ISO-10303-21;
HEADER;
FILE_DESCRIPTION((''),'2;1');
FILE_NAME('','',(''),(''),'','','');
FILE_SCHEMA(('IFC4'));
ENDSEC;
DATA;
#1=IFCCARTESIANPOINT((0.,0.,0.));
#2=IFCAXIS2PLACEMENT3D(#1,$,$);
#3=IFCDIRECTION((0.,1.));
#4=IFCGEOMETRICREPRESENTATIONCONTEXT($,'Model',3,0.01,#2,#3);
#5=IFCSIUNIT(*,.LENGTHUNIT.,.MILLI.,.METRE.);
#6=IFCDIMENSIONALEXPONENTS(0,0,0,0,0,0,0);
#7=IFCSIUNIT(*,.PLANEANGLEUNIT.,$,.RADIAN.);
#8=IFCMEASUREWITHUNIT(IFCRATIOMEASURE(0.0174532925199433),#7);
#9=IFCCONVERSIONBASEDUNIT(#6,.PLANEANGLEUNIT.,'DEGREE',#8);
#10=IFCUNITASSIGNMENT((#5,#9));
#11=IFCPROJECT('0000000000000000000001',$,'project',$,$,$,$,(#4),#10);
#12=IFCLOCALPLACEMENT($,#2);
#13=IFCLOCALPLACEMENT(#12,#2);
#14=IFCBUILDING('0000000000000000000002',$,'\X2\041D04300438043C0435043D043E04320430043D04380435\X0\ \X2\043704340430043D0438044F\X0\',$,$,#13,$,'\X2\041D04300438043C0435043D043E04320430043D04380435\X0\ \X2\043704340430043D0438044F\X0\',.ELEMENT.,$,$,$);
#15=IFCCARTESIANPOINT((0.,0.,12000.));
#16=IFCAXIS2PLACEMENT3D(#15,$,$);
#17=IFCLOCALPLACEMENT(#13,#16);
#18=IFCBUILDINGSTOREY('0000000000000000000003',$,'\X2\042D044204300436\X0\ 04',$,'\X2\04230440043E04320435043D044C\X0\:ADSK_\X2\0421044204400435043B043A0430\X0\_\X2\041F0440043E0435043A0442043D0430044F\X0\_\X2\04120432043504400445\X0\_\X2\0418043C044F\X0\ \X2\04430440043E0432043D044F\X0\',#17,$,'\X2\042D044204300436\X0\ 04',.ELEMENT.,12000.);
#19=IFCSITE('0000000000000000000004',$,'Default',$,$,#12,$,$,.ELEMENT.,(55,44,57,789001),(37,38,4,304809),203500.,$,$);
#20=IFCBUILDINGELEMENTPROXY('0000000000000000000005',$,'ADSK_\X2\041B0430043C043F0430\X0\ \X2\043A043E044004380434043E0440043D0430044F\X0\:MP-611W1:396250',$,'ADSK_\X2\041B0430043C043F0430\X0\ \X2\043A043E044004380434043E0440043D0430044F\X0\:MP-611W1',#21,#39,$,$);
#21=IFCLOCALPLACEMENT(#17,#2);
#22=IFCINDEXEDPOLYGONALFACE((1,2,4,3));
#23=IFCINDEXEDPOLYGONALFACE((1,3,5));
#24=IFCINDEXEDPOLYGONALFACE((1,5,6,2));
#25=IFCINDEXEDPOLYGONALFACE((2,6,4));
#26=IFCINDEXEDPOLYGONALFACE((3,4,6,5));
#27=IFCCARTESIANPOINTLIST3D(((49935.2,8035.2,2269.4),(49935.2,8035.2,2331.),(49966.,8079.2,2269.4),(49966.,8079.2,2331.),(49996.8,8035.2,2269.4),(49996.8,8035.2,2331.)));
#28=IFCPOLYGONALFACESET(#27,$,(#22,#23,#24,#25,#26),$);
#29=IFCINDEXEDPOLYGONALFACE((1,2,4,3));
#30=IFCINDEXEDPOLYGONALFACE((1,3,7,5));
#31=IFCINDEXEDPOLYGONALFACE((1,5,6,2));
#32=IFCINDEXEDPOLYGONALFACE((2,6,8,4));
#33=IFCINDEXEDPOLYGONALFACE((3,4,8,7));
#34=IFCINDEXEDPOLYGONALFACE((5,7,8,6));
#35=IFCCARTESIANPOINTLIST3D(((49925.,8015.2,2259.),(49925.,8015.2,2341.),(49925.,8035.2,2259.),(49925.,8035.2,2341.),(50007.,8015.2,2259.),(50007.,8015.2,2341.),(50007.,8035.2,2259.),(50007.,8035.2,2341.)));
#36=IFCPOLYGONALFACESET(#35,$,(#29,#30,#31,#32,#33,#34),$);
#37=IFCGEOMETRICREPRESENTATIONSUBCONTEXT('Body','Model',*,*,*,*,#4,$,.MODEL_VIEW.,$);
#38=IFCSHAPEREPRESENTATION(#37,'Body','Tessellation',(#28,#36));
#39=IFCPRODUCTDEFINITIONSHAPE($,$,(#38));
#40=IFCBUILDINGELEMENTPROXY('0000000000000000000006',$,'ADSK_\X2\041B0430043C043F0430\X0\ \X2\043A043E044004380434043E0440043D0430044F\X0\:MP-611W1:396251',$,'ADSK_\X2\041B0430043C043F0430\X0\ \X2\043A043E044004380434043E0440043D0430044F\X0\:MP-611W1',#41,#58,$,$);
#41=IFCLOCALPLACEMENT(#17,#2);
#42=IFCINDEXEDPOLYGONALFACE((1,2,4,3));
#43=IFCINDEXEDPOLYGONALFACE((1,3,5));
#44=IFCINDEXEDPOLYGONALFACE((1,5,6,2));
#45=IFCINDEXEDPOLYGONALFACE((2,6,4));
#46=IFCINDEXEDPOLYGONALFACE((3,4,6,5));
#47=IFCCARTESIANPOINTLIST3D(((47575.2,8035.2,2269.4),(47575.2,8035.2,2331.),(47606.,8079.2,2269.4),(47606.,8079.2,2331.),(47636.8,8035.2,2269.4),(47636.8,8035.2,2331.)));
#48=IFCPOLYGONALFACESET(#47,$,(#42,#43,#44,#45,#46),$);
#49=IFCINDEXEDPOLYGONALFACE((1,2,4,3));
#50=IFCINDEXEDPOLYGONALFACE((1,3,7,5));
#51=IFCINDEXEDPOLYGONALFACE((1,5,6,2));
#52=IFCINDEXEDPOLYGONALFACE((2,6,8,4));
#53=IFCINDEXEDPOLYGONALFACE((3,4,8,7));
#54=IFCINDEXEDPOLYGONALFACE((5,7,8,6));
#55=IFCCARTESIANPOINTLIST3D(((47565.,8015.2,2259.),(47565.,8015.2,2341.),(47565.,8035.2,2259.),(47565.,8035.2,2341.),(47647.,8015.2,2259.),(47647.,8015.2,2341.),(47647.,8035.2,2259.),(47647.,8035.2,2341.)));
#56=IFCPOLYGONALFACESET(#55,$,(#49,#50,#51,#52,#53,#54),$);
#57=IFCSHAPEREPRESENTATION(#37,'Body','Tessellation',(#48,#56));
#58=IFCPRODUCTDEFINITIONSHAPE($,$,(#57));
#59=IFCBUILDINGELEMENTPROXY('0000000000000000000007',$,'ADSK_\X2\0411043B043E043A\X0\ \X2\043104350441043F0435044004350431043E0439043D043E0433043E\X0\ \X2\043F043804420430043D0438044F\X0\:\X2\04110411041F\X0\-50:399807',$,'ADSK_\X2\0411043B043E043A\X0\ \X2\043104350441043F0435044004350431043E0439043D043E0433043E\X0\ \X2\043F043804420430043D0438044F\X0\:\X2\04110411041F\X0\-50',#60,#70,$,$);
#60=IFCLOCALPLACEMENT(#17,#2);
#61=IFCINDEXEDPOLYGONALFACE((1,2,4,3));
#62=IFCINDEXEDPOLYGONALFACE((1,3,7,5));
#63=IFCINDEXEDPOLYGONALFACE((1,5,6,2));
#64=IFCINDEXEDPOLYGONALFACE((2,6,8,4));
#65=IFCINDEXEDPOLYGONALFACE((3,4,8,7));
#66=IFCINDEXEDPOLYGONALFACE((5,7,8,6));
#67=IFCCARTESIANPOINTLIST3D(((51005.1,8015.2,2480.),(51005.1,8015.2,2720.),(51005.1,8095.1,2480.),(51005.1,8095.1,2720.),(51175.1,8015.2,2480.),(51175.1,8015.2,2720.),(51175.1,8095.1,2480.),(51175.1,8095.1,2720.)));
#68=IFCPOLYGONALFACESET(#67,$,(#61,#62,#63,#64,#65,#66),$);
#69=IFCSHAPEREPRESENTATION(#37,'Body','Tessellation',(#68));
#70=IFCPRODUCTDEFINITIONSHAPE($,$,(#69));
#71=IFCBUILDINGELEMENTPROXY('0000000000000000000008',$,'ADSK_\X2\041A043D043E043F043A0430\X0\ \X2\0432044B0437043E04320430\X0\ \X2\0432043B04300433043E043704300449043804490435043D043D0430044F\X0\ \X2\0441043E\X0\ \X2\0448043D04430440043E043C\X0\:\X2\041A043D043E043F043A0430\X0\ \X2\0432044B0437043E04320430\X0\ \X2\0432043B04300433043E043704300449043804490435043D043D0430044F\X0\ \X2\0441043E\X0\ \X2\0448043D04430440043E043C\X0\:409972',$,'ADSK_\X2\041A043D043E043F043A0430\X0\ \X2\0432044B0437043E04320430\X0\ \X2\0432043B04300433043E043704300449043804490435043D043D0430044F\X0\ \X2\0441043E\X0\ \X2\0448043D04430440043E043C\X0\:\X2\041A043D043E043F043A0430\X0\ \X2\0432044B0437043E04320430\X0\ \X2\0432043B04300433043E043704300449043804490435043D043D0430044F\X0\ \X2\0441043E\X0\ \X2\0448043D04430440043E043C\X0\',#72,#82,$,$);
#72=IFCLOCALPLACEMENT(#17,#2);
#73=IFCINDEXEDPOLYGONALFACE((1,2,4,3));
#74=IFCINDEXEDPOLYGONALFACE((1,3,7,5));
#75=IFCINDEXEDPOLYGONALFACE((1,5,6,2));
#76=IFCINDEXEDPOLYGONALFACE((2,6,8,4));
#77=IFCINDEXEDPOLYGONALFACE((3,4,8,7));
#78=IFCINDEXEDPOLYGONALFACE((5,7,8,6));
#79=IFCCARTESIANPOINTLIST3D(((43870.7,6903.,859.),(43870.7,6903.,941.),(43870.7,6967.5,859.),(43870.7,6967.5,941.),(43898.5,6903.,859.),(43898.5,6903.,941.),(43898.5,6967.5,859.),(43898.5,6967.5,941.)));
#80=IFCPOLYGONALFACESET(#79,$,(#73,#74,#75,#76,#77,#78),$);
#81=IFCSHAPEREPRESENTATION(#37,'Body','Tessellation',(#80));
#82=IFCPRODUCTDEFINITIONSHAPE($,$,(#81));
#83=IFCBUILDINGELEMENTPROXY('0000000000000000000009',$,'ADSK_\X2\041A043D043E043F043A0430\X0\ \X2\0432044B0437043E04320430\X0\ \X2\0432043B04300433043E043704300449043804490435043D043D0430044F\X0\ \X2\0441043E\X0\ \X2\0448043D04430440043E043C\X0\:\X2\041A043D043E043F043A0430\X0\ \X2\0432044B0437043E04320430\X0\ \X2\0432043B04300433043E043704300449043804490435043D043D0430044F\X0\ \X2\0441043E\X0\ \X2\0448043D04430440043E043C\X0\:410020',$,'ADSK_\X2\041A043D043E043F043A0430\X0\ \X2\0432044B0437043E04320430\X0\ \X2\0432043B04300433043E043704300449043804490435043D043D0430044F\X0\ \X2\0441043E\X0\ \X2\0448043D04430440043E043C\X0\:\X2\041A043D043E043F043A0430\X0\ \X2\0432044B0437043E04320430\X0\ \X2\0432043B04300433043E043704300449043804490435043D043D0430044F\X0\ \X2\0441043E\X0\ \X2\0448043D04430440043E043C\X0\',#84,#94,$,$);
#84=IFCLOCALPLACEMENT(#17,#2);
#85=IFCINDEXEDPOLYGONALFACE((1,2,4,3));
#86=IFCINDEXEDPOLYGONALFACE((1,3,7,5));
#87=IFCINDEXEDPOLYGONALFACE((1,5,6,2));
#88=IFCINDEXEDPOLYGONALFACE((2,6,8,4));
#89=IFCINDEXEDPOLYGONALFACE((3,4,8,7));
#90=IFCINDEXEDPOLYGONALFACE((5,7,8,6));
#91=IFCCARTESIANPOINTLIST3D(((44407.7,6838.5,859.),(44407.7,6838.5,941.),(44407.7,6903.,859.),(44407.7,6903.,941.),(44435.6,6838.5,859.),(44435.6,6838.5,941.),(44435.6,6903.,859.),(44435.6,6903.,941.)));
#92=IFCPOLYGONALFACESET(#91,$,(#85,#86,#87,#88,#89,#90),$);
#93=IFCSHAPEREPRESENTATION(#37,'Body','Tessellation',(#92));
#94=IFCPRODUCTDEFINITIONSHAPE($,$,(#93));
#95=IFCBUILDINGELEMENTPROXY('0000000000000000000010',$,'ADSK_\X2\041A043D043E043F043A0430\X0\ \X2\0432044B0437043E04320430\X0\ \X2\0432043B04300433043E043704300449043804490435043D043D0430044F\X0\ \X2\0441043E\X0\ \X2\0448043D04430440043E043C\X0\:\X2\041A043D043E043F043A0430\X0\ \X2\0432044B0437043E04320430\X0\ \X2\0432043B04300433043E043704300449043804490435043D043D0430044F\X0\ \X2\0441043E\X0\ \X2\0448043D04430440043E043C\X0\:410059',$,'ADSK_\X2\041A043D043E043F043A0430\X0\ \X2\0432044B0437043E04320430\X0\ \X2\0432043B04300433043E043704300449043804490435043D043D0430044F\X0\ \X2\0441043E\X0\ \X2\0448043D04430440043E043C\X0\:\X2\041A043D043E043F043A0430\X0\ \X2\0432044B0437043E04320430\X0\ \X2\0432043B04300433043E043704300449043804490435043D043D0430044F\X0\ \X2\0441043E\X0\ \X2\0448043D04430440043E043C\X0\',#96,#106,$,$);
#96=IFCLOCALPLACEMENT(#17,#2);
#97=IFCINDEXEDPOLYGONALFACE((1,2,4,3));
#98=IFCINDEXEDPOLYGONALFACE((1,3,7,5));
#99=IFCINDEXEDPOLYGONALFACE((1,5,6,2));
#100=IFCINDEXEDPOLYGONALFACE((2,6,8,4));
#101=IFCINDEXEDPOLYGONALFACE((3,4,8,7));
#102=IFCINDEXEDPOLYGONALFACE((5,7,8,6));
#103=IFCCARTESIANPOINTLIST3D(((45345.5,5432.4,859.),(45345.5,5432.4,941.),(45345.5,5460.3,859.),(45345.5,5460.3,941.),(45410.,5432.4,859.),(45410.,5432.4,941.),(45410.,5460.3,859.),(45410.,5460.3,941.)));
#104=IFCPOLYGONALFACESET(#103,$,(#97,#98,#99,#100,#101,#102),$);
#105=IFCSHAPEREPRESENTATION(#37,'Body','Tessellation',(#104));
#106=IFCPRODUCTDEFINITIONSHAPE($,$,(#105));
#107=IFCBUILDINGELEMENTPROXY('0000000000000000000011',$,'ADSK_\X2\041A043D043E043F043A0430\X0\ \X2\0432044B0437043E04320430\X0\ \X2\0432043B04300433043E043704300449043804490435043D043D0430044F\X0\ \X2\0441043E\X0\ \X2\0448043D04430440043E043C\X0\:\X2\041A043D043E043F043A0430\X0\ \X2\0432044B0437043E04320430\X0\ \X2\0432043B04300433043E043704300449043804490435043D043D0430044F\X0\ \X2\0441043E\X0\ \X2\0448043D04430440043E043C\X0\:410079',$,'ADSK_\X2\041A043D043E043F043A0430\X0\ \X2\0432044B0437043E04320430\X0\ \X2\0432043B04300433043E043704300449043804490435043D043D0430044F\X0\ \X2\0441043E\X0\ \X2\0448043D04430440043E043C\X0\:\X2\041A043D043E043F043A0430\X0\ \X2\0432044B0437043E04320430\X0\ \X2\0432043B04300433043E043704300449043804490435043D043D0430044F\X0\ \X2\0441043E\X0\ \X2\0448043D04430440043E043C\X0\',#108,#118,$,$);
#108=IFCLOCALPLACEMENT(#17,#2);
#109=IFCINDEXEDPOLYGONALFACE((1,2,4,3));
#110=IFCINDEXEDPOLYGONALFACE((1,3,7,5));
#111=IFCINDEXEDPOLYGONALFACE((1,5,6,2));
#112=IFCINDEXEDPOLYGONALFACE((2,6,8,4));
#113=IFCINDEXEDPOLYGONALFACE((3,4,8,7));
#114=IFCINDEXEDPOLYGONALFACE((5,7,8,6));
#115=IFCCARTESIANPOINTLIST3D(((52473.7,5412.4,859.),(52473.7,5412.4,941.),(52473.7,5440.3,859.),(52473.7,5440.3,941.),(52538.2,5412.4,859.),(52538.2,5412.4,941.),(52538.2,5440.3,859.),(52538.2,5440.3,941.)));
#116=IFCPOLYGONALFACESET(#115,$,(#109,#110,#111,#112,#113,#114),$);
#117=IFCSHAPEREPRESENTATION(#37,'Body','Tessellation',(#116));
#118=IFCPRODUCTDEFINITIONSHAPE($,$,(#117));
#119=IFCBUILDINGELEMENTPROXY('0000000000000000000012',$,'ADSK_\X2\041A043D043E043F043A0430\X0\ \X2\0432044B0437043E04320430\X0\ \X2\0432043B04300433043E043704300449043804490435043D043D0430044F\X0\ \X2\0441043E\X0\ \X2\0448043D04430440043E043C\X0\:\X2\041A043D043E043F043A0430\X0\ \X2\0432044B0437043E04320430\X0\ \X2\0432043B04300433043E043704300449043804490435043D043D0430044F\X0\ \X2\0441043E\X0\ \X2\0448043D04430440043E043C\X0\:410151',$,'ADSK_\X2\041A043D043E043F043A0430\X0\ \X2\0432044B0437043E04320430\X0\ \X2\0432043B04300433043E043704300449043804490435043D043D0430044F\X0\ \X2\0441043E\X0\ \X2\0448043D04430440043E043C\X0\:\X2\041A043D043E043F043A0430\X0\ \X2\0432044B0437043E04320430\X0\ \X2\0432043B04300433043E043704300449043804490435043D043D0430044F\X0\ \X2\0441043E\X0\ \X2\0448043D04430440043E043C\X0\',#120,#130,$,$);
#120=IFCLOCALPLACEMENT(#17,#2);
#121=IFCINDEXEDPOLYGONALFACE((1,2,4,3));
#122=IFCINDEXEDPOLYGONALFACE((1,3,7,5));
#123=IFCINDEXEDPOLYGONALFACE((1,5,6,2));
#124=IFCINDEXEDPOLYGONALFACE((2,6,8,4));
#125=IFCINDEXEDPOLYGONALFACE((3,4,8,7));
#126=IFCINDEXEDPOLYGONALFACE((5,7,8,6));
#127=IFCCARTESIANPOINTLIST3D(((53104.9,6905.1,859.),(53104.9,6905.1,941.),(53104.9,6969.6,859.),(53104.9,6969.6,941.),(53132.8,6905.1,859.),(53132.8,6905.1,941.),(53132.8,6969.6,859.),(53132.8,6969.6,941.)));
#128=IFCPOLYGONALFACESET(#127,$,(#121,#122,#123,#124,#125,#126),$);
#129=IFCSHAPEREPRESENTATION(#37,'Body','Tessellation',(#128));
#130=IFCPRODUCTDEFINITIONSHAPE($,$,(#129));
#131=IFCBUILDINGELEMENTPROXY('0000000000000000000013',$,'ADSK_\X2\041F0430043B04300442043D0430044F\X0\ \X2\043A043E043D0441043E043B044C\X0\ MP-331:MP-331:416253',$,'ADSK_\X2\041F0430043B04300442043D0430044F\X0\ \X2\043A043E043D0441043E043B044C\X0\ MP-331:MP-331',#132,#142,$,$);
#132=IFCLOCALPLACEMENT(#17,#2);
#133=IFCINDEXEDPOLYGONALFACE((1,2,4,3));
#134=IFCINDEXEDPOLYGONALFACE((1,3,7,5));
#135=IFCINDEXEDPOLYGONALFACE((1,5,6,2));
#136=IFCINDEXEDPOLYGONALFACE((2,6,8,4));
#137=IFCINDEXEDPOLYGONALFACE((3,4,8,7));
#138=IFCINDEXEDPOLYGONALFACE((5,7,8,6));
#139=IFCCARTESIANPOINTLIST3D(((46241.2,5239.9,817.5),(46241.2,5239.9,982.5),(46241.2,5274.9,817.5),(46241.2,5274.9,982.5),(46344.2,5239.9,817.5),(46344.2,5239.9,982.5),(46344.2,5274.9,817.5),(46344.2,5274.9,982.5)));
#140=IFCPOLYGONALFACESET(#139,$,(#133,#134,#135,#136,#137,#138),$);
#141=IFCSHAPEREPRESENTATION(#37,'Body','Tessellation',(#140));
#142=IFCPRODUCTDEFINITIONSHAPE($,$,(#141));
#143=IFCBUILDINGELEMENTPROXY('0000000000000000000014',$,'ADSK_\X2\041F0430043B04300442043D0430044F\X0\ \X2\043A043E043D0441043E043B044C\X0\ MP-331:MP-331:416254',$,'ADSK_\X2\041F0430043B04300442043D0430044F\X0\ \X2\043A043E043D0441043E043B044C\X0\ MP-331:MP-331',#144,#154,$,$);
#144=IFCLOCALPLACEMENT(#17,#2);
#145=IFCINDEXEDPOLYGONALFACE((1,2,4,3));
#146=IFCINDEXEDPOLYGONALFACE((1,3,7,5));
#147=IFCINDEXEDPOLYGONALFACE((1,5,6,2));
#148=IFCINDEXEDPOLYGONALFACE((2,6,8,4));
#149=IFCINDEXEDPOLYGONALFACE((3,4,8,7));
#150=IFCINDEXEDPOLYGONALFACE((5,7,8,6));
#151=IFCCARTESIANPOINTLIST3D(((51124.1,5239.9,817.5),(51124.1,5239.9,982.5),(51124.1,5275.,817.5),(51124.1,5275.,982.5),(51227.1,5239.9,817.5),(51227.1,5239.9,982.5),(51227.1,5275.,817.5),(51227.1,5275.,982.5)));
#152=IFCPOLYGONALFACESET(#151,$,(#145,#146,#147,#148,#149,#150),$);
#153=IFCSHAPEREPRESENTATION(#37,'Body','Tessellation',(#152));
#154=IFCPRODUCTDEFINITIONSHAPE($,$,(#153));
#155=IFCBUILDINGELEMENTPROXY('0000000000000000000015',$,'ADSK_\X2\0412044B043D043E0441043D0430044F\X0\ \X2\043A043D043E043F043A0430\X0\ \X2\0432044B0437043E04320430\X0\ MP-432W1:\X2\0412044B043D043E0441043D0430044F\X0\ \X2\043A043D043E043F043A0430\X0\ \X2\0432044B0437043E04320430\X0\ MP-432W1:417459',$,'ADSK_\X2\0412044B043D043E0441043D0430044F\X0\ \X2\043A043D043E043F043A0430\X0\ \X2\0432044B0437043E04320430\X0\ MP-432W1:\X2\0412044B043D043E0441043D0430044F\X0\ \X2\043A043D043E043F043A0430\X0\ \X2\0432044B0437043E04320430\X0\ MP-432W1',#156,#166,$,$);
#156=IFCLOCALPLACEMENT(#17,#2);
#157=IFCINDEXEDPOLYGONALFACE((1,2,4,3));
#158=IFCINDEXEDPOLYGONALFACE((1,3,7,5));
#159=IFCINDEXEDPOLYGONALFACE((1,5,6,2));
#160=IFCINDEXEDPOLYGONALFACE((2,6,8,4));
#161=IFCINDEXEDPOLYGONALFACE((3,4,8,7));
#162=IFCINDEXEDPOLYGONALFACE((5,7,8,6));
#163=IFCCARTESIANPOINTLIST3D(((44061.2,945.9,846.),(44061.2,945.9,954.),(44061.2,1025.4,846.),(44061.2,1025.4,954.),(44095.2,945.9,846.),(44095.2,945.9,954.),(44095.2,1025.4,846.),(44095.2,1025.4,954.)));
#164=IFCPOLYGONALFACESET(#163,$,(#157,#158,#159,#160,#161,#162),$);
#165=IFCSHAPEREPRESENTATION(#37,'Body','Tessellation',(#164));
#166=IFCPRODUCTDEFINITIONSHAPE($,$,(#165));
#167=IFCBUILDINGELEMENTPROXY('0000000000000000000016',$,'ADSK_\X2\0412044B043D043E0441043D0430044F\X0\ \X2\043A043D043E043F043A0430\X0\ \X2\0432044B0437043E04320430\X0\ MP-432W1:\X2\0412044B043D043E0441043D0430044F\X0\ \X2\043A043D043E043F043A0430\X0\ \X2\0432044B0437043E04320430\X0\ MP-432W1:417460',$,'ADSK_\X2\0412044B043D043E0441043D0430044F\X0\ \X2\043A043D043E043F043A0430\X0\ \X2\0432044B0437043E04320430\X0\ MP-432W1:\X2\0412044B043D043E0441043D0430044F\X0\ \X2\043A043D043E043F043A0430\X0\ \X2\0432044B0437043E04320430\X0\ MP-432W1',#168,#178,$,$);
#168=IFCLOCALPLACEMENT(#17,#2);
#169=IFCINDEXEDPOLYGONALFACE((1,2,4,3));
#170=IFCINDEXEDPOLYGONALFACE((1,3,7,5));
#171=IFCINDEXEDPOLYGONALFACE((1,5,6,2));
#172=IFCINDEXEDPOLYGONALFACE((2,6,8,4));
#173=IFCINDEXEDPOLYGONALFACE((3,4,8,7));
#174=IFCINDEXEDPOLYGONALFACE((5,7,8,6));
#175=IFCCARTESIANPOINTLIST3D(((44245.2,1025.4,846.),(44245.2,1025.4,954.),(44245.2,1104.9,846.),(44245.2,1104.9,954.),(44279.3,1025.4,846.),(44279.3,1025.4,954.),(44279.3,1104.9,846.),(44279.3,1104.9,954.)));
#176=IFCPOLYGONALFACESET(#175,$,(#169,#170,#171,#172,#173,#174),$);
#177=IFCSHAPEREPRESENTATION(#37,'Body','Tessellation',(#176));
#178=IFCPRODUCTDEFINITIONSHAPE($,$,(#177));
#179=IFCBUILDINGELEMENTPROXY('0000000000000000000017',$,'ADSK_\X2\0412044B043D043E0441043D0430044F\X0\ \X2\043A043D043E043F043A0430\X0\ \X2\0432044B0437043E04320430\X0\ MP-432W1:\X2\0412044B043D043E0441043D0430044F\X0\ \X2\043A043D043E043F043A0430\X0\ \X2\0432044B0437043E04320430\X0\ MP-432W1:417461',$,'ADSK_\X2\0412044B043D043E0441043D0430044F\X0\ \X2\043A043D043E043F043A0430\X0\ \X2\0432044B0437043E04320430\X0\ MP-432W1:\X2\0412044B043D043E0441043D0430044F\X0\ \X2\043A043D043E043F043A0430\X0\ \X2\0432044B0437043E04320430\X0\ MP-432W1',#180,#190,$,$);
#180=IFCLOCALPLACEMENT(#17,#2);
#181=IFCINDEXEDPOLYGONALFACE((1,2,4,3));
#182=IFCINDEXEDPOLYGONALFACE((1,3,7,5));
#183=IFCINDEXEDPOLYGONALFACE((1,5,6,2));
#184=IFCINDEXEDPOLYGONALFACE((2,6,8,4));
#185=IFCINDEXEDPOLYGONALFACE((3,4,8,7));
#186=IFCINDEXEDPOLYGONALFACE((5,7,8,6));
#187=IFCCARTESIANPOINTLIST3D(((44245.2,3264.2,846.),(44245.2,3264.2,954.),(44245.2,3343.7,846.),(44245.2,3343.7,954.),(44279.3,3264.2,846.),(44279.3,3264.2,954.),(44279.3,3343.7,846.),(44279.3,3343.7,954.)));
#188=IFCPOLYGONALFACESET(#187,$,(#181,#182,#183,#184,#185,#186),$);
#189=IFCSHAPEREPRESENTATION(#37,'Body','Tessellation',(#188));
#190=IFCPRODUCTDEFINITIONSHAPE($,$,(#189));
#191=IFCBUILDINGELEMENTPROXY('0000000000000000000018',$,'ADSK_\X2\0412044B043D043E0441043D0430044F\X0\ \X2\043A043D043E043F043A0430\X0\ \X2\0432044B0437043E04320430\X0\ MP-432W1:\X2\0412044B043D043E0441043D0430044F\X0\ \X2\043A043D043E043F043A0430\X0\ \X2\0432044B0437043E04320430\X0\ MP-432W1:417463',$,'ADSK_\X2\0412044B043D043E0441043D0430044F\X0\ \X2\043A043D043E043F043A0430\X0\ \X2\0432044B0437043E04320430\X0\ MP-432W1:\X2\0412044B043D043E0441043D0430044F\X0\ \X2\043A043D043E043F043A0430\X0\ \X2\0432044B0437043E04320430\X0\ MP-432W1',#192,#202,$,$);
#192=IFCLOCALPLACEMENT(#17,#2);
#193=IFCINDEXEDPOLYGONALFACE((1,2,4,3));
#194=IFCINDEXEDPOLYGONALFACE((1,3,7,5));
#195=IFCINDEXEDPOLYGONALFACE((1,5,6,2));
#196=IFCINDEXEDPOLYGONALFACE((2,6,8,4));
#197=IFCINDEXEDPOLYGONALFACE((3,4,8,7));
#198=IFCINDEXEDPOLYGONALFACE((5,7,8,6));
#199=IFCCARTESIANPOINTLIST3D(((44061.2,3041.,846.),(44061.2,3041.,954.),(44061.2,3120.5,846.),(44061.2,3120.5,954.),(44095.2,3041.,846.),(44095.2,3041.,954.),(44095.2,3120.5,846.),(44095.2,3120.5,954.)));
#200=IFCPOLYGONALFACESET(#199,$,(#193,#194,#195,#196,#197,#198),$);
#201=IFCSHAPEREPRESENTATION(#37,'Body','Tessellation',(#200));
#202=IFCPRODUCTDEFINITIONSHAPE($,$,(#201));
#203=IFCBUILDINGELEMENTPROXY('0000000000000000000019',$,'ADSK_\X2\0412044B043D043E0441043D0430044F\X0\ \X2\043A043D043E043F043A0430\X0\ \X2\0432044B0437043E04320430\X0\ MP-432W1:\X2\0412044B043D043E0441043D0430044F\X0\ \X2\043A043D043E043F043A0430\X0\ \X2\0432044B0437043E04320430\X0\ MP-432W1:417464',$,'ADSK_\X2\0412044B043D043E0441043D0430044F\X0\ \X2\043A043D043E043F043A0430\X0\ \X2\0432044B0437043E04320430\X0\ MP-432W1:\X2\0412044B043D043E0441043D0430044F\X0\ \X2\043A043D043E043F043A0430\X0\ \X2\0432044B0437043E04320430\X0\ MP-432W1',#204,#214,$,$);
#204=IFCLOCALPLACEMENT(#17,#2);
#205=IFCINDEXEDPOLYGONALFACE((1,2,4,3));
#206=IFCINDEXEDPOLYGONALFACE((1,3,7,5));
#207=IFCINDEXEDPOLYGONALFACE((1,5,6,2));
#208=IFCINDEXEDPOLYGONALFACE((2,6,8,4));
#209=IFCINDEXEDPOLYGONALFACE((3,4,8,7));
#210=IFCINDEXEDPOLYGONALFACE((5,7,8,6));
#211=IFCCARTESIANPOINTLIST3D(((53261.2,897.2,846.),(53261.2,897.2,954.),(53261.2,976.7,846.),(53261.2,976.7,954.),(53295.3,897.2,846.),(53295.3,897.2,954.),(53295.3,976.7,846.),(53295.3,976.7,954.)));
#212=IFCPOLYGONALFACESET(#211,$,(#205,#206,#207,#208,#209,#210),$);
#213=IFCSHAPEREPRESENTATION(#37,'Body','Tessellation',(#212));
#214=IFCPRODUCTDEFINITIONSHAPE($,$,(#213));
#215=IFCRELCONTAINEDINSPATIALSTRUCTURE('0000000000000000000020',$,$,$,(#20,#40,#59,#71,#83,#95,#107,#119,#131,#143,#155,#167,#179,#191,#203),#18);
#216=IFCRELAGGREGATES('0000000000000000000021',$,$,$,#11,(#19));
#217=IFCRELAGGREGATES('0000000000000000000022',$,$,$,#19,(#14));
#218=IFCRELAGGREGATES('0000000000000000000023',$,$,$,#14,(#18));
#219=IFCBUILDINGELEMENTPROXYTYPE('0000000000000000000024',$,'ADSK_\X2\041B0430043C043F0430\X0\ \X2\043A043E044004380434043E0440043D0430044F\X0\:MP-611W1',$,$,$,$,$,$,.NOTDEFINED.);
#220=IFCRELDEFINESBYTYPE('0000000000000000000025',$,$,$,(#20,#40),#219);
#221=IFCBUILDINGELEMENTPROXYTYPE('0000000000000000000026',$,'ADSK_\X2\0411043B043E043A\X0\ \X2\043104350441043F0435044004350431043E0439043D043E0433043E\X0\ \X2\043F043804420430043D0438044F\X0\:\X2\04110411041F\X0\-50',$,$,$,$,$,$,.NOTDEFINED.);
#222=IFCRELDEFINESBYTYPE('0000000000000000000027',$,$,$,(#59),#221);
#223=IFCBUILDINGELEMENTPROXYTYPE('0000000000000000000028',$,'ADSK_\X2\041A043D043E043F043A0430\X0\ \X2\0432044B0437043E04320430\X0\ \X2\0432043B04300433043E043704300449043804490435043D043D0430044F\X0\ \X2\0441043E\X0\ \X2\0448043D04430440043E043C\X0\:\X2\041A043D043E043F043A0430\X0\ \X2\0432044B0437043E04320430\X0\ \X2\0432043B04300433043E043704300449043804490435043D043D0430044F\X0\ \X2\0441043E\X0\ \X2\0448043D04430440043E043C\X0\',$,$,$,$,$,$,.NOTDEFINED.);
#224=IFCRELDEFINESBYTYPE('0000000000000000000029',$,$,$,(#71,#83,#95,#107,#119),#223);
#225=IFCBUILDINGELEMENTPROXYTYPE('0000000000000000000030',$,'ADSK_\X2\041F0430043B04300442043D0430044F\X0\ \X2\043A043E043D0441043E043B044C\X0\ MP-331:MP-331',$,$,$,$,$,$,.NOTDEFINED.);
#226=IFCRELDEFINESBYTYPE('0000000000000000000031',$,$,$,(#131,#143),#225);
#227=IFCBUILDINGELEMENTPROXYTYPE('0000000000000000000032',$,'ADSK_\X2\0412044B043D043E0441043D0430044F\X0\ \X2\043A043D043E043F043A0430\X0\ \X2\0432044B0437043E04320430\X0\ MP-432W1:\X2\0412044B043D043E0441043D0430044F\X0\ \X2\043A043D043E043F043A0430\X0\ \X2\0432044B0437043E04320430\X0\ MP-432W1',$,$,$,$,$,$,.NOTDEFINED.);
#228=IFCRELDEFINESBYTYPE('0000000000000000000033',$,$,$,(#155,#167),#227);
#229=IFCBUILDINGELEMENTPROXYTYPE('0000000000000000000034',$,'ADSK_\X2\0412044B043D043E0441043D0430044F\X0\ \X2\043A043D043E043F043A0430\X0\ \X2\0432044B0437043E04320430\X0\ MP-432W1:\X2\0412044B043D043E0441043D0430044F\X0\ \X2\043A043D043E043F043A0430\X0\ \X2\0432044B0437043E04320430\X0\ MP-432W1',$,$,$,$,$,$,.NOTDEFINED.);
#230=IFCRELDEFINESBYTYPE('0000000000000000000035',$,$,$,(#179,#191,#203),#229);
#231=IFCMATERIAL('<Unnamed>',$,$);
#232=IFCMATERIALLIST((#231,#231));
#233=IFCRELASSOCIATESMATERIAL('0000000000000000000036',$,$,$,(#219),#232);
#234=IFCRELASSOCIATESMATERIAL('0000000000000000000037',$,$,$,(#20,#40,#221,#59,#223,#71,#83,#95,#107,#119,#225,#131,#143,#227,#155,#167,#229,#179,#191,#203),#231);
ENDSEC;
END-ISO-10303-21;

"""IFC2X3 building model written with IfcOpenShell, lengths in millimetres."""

from ifc_helpers import new_model, entity, si_unit, converted_unit, direction, frame, origin, origin_2d_with_axis, place, context, subcontext, project, spatial, polyline, rectangle, outline, extrude, source, transform, mapped, material, material_list, type_object, type_shapes, element, save


model = new_model("IFC2X3")

# Units and contexts
model_context = context("Model", 3, precision=0.01, world=origin(), true_north=direction((0.0, 1.0)))
body_context = subcontext(model_context, "Body", "Model", "MODEL_VIEW")
ifc_project = project(units=[si_unit("LENGTHUNIT", "METRE", prefix="MILLI"), converted_unit("PLANEANGLEUNIT", "DEGREE", entity("IfcRatioMeasure", 0.0174532925199433), si_unit("PLANEANGLEUNIT", "RADIAN"), dimensions=[0, 0, 0, 0, 0, 0, 0])], contexts=[model_context])

# Site, building, storey
site_placement = place(None, origin())
site = spatial("IfcSite", under=ifc_project, at=site_placement, Name="Default", CompositionType="ELEMENT", RefLatitude=(55, 44, 57, 789001), RefLongitude=(37, 38, 4, 304809), RefElevation=203500.0)
building_placement = place(site_placement, origin())
building = spatial("IfcBuilding", under=site, at=building_placement, Name="Наименование здания", LongName="Наименование здания", CompositionType="ELEMENT")
storey_placement = place(building_placement, frame((0.0, 0.0, 12000.0)))
storey = spatial("IfcBuildingStorey", under=building, at=storey_placement, Name="Этаж 04", ObjectType="Уровень:ADSK_Стрелка_Проектная_Вверх_Имя уровня", LongName="Этаж 04", CompositionType="ELEMENT", Elevation=12000.0)

# Building element proxies
ifc_material = material(Name="<Unnamed>")
ifc_material_list = material_list([ifc_material, ifc_material])
building_element_proxy_type_1 = type_object("IfcBuildingElementProxyType", Name="ADSK_Лампа коридорная:MP-611W1", PredefinedType="NOTDEFINED", material=ifc_material_list)
shared_shape_1 = source(origin(), body_context, "Body", "SweptSolid", [
    extrude(outline(polyline([(-30.8, -14.7), (30.8, -14.7), (0.0, 29.3), (-30.8, -14.7)])), frame((0.0, -2.7, -30.6), z_axis=(0.0, 0.0, 1.0), x_axis=(-1.0, 0.0, 0.0)), (0.0, 0.0, 1.0), 61.6),
    extrude(rectangle(XDim=82.0, YDim=20.0, at=origin_2d_with_axis()), frame((0.0, 22.0, -41.0), z_axis=(0.0, 0.0, 1.0), x_axis=(-1.0, 0.0, 0.0)), (0.0, 0.0, 1.0), 82.0),
])
type_shapes(building_element_proxy_type_1, [shared_shape_1])
for number, where, z_axis, x_axis, name in (
    (1, (49966.0, 8047.1, 2300.0), (0.0, 0.0, 1.0), (-1.0, 0.0, 0.0), "ADSK_Лампа коридорная:MP-611W1:396250"),
    (2, (47606.0, 8047.1, 2300.0), (0.0, 0.0, 1.0), (-1.0, 0.0, 0.0), "ADSK_Лампа коридорная:MP-611W1:396251"),
):
    element("IfcBuildingElementProxy", number, at=place(storey_placement, frame(where, z_axis=z_axis, x_axis=x_axis)), inside=storey, type_object=building_element_proxy_type_1, material=ifc_material, Name=name, ObjectType="ADSK_Лампа коридорная:MP-611W1", context=body_context, shape_type="MappedRepresentation", body=[
        mapped(shared_shape_1, transform((0.0, 0.0, 0.0), scale=1.0)),
    ])
building_element_proxy_type_2 = type_object("IfcBuildingElementProxyType", Name="ADSK_Блок бесперебойного питания:ББП-50", PredefinedType="NOTDEFINED", material=ifc_material)
shared_shape_2 = source(origin(), body_context, "Body", "SweptSolid", [
    extrude(rectangle(XDim=170.0, YDim=80.0, at=origin_2d_with_axis()), frame((0.0, -8.0, -120.0), z_axis=(0.0, 0.0, 1.0), x_axis=(-1.0, 0.0, 0.0)), (0.0, 0.0, 1.0), 240.0),
])
type_shapes(building_element_proxy_type_2, [shared_shape_2])
proxy_1_placement = place(storey_placement, frame((51090.1, 8047.1, 2600.0), z_axis=(0.0, 0.0, 1.0), x_axis=(-1.0, 0.0, 0.0)))
element("IfcBuildingElementProxy", 3, at=proxy_1_placement, inside=storey, type_object=building_element_proxy_type_2, material=ifc_material, Name="ADSK_Блок бесперебойного питания:ББП-50:399807", ObjectType="ADSK_Блок бесперебойного питания:ББП-50", context=body_context, shape_type="MappedRepresentation", body=[
    mapped(shared_shape_2, transform((0.0, 0.0, 0.0), scale=1.0)),
])
building_element_proxy_type_3 = type_object("IfcBuildingElementProxyType", Name="ADSK_Кнопка вызова влагозащищенная со шнуром:Кнопка вызова влагозащищенная со шнуром", PredefinedType="NOTDEFINED", material=ifc_material)
shared_shape_3 = source(origin(), body_context, "Body", "SweptSolid", [
    extrude(rectangle(XDim=64.5, YDim=27.8, at=origin_2d_with_axis()), frame((32.2, 13.9, 0.0), z_axis=(0.0, 0.0, 1.0), x_axis=(-1.0, 0.0, 0.0)), (0.0, 0.0, 1.0), 82.0),
])
type_shapes(building_element_proxy_type_3, [shared_shape_3])
for number, where, z_axis, x_axis, name in (
    (4, (43870.7, 6967.5, 859.0), (0.0, 0.0, 1.0), (0.0, -1.0, 0.0), "ADSK_Кнопка вызова влагозащищенная со шнуром:Кнопка вызова влагозащищенная со шнуром:409972"),
    (5, (44435.6, 6838.5, 859.0), (0.0, 0.0, 1.0), (0.0, 1.0, 0.0), "ADSK_Кнопка вызова влагозащищенная со шнуром:Кнопка вызова влагозащищенная со шнуром:410020"),
    (6, (45410.0, 5460.3, 859.0), (0.0, 0.0, 1.0), (-1.0, 0.0, 0.0), "ADSK_Кнопка вызова влагозащищенная со шнуром:Кнопка вызова влагозащищенная со шнуром:410059"),
    (7, (52538.2, 5440.3, 859.0), (0.0, 0.0, 1.0), (-1.0, 0.0, 0.0), "ADSK_Кнопка вызова влагозащищенная со шнуром:Кнопка вызова влагозащищенная со шнуром:410079"),
    (8, (53104.9, 6969.6, 859.0), (0.0, 0.0, 1.0), (0.0, -1.0, 0.0), "ADSK_Кнопка вызова влагозащищенная со шнуром:Кнопка вызова влагозащищенная со шнуром:410151"),
):
    element("IfcBuildingElementProxy", number, at=place(storey_placement, frame(where, z_axis=z_axis, x_axis=x_axis)), inside=storey, type_object=building_element_proxy_type_3, material=ifc_material, Name=name, ObjectType="ADSK_Кнопка вызова влагозащищенная со шнуром:Кнопка вызова влагозащищенная со шнуром", context=body_context, shape_type="MappedRepresentation", body=[
        mapped(shared_shape_3, transform((0.0, 0.0, 0.0), scale=1.0)),
    ])
building_element_proxy_type_4 = type_object("IfcBuildingElementProxyType", Name="ADSK_Палатная консоль MP-331:MP-331", PredefinedType="NOTDEFINED", material=ifc_material)
shared_shape_4 = source(origin(), body_context, "Body", "SweptSolid", [
    extrude(rectangle(XDim=103.0, YDim=35.0, at=origin_2d_with_axis()), frame((0.0, 14.5, -82.5), z_axis=(0.0, 0.0, 1.0), x_axis=(-1.0, 0.0, 0.0)), (0.0, 0.0, 1.0), 165.0),
])
type_shapes(building_element_proxy_type_4, [shared_shape_4])
for number, where, name in (
    (9, (46292.7, 5242.9, 900.0), "ADSK_Палатная консоль MP-331:MP-331:416253"),
    (10, (51175.6, 5242.9, 900.0), "ADSK_Палатная консоль MP-331:MP-331:416254"),
):
    element("IfcBuildingElementProxy", number, at=place(storey_placement, frame(where)), inside=storey, type_object=building_element_proxy_type_4, material=ifc_material, Name=name, ObjectType="ADSK_Палатная консоль MP-331:MP-331", context=body_context, shape_type="MappedRepresentation", body=[
        mapped(shared_shape_4, transform((0.0, 0.0, 0.0), scale=1.0)),
    ])
building_element_proxy_type_5 = type_object("IfcBuildingElementProxyType", Name="ADSK_Выносная кнопка вызова MP-432W1:Выносная кнопка вызова MP-432W1", PredefinedType="NOTDEFINED", material=ifc_material)
shared_shape_5 = source(origin(), body_context, "Body", "SweptSolid", [
    extrude(rectangle(XDim=79.5, YDim=34.1, at=origin_2d_with_axis()), frame((0.0, 15.0, -54.0), z_axis=(0.0, 0.0, 1.0), x_axis=(-1.0, 0.0, 0.0)), (0.0, 0.0, 1.0), 108.0),
])
type_shapes(building_element_proxy_type_5, [shared_shape_5])
for number, where, z_axis, x_axis, name in (
    (11, (44063.2, 985.6, 900.0), (0.0, 0.0, 1.0), (0.0, -1.0, 0.0), "ADSK_Выносная кнопка вызова MP-432W1:Выносная кнопка вызова MP-432W1:417459"),
    (12, (44277.2, 1065.1, 900.0), (0.0, 0.0, 1.0), (0.0, 1.0, 0.0), "ADSK_Выносная кнопка вызова MP-432W1:Выносная кнопка вызова MP-432W1:417460"),
):
    element("IfcBuildingElementProxy", number, at=place(storey_placement, frame(where, z_axis=z_axis, x_axis=x_axis)), inside=storey, type_object=building_element_proxy_type_5, material=ifc_material, Name=name, ObjectType="ADSK_Выносная кнопка вызова MP-432W1:Выносная кнопка вызова MP-432W1", context=body_context, shape_type="MappedRepresentation", body=[
        mapped(shared_shape_5, transform((0.0, 0.0, 0.0), scale=1.0)),
    ])
building_element_proxy_type_6 = type_object("IfcBuildingElementProxyType", Name="ADSK_Выносная кнопка вызова MP-432W1:Выносная кнопка вызова MP-432W1", PredefinedType="NOTDEFINED", material=ifc_material)
type_shapes(building_element_proxy_type_6, [shared_shape_5])
for number, where, z_axis, x_axis, name in (
    (13, (44277.2, 3304.0, 900.0), (0.0, 0.0, 1.0), (0.0, 1.0, 0.0), "ADSK_Выносная кнопка вызова MP-432W1:Выносная кнопка вызова MP-432W1:417461"),
    (14, (44063.2, 3080.8, 900.0), (0.0, 0.0, 1.0), (0.0, -1.0, 0.0), "ADSK_Выносная кнопка вызова MP-432W1:Выносная кнопка вызова MP-432W1:417463"),
    (15, (53263.2, 937.0, 900.0), (0.0, 0.0, 1.0), (0.0, -1.0, 0.0), "ADSK_Выносная кнопка вызова MP-432W1:Выносная кнопка вызова MP-432W1:417464"),
):
    element("IfcBuildingElementProxy", number, at=place(storey_placement, frame(where, z_axis=z_axis, x_axis=x_axis)), inside=storey, type_object=building_element_proxy_type_6, material=ifc_material, Name=name, ObjectType="ADSK_Выносная кнопка вызова MP-432W1:Выносная кнопка вызова MP-432W1", context=body_context, shape_type="MappedRepresentation", body=[
        mapped(shared_shape_5, transform((0.0, 0.0, 0.0), scale=1.0)),
    ])

save(model, "model.ifc")
